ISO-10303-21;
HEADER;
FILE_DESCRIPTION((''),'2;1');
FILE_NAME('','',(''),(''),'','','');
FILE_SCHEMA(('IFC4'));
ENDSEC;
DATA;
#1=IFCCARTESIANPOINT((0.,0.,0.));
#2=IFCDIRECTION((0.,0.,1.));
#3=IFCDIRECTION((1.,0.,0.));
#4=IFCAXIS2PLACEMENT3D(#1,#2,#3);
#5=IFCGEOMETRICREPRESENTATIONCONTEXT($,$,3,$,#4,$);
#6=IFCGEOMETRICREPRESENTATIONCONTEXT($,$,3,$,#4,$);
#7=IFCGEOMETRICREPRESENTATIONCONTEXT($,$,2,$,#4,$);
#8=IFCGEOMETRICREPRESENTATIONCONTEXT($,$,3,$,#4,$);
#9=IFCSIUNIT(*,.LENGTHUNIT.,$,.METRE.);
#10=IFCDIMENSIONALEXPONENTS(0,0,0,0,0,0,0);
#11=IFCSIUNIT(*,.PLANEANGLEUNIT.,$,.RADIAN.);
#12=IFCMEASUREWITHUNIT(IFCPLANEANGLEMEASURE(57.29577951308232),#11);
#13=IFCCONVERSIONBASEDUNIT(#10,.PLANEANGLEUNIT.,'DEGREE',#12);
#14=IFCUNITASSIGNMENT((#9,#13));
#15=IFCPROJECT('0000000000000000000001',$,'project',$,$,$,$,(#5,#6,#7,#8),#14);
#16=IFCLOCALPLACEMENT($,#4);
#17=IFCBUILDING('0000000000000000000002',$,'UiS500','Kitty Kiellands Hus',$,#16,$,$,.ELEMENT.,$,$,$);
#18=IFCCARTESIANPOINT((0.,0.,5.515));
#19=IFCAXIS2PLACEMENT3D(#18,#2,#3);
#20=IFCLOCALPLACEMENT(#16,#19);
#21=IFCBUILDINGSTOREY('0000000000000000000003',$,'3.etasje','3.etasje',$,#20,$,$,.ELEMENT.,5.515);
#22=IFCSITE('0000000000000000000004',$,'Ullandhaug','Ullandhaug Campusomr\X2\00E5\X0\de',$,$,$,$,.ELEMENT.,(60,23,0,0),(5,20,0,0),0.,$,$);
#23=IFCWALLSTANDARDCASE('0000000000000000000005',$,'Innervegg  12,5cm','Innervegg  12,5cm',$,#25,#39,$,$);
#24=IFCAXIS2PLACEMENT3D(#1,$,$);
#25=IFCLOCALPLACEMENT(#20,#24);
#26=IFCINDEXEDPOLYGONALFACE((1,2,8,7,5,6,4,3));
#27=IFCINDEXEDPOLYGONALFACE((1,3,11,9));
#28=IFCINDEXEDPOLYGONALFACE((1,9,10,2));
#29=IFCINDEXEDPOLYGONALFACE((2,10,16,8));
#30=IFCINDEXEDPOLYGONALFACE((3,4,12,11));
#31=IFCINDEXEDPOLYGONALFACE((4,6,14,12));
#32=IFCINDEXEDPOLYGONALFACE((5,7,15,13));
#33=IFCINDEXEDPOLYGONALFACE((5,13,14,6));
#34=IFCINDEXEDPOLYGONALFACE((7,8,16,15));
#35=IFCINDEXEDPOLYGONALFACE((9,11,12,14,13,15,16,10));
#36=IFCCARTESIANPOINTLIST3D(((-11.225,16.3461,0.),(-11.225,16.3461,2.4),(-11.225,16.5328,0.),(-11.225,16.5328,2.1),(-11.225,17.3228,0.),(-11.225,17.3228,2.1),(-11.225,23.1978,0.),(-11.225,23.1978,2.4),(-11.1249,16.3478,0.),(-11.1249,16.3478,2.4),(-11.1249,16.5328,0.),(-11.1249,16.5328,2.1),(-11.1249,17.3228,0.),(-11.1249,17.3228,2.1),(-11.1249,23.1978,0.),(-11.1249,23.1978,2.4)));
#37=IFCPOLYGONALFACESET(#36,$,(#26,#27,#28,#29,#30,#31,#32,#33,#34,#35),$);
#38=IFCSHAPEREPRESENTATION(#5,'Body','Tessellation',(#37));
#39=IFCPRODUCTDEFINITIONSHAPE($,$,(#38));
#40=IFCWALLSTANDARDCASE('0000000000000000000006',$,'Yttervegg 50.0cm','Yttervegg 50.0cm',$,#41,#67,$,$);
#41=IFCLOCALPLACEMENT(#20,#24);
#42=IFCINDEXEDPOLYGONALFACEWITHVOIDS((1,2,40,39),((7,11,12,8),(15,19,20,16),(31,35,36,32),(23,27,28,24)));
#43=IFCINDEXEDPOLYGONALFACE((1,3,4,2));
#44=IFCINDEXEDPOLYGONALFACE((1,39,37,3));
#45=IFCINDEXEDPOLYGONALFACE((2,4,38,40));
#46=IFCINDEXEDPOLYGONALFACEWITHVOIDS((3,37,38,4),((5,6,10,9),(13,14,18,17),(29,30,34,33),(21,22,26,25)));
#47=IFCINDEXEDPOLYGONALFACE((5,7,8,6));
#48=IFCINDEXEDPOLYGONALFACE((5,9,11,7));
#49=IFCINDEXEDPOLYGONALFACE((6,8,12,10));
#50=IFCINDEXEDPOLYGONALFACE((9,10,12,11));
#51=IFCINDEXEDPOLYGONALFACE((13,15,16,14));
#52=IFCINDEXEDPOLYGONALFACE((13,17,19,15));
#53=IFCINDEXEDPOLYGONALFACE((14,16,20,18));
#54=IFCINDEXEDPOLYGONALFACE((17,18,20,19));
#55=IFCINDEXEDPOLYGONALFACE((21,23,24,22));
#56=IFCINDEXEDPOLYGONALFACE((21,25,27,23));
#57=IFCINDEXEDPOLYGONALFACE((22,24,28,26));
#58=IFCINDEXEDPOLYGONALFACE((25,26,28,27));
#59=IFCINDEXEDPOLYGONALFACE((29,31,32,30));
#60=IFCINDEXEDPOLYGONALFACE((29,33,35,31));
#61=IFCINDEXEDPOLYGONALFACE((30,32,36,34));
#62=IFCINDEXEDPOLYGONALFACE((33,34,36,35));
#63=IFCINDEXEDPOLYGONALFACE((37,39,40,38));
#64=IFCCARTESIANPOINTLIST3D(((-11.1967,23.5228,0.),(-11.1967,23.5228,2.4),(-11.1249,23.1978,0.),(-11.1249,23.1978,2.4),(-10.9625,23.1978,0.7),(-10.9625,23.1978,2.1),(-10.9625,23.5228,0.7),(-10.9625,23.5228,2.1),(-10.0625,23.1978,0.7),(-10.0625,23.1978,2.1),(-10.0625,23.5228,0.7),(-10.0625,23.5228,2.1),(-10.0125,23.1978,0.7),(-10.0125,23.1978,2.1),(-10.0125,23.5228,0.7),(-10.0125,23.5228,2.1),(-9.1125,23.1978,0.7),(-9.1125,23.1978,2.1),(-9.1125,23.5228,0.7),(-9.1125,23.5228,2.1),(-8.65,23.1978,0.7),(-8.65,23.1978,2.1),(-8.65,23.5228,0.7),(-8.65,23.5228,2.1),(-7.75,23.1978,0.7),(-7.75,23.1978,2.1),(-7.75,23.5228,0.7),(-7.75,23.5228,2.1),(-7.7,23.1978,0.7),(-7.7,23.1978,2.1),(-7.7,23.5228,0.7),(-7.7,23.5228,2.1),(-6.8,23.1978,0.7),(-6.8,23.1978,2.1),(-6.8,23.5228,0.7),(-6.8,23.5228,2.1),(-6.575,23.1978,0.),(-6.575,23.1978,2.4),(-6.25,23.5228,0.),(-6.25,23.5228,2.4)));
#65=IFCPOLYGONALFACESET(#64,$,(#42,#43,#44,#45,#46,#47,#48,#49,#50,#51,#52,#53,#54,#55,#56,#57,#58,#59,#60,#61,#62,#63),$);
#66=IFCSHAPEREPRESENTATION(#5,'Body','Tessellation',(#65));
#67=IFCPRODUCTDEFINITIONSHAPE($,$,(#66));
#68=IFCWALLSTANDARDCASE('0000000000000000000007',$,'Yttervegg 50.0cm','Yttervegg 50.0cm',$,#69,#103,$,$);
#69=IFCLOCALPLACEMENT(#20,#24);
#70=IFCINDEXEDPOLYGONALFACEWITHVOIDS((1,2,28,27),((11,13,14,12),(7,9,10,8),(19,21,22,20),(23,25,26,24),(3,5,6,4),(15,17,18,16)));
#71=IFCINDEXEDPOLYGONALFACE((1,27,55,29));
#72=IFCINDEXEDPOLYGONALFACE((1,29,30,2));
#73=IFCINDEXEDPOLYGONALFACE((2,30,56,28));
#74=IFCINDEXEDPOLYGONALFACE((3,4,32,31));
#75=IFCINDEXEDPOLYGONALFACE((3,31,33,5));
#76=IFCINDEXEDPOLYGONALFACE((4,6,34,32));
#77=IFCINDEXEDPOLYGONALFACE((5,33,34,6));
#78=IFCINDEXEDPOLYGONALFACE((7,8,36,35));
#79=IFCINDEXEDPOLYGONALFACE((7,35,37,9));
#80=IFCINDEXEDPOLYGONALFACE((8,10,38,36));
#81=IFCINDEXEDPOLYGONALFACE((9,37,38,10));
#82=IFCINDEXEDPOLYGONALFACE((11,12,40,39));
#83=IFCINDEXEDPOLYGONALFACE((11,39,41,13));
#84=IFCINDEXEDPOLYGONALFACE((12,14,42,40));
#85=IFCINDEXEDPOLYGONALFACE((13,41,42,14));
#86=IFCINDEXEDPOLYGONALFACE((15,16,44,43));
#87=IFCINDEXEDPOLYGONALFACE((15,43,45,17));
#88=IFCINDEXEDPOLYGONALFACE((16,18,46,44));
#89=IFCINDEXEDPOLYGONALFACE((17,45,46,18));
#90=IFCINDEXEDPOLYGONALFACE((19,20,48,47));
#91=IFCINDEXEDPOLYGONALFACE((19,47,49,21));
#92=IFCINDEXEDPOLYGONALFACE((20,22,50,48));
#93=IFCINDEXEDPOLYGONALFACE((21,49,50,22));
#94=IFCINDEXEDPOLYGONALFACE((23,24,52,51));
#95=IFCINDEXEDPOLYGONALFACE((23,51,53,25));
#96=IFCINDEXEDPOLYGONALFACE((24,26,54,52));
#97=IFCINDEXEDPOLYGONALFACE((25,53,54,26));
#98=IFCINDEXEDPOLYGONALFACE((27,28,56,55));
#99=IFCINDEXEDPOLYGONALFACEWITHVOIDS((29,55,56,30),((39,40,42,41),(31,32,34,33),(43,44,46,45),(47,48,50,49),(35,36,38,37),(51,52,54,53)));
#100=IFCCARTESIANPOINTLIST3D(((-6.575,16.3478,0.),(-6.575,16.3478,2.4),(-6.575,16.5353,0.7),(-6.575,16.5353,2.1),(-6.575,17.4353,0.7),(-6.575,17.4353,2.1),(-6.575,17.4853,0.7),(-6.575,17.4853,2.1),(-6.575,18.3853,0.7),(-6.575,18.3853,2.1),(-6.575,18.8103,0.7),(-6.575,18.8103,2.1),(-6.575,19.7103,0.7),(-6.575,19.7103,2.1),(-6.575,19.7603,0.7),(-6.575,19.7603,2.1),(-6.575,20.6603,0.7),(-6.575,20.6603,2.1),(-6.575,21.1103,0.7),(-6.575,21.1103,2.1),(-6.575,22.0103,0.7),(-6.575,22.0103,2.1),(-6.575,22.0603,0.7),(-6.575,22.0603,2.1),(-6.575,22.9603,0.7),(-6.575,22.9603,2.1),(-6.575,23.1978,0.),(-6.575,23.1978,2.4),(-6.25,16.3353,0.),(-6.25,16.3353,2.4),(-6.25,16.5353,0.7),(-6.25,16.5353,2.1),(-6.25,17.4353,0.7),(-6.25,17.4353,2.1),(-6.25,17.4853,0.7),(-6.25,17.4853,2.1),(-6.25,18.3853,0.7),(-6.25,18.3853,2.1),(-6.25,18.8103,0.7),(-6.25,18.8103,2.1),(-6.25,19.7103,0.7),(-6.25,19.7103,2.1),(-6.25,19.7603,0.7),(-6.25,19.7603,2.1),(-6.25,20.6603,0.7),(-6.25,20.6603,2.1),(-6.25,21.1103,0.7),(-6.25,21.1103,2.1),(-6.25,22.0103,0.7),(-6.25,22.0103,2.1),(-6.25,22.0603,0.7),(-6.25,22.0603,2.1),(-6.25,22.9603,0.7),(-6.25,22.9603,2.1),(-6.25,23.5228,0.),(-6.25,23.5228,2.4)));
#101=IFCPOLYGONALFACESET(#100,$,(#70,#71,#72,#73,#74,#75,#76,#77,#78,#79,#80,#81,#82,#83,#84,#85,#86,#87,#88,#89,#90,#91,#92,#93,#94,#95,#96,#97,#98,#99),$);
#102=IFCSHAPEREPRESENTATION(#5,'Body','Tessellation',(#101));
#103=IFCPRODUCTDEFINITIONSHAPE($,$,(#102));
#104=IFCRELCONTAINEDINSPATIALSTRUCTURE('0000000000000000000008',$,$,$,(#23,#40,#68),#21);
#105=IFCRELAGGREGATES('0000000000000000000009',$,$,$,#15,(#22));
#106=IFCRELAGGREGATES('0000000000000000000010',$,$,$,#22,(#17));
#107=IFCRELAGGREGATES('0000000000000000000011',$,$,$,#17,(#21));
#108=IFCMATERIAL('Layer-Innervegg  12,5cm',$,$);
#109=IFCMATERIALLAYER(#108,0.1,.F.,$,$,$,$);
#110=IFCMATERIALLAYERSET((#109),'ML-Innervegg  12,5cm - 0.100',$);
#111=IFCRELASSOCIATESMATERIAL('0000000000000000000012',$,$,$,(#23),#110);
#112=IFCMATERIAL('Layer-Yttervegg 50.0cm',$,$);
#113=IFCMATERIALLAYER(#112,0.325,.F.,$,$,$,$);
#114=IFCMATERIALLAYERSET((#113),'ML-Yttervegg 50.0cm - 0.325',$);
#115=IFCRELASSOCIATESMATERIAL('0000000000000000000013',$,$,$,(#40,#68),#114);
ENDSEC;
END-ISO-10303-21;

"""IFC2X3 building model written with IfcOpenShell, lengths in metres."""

from ifc_helpers import new_model, entity, si_unit, converted_unit, frame, origin_with_axes, place, context, project, spatial, polyline, outline, extrude, material, layer, layer_set, layer_usage, element, save


model = new_model("IFC2X3")

# Units and contexts
context_of_model_1 = context(None, 3, world=origin_with_axes())
context_of_model_2 = context(None, 3, world=origin_with_axes())
context_of_model_3 = context(None, 2, world=origin_with_axes())
context_of_model_4 = context(None, 3, world=origin_with_axes())
ifc_project = project(units=[si_unit("LENGTHUNIT", "METRE"), converted_unit("PLANEANGLEUNIT", "DEGREE", entity("IfcPlaneAngleMeasure", 57.29577951308232), si_unit("PLANEANGLEUNIT", "RADIAN"), dimensions=[0, 0, 0, 0, 0, 0, 0])], contexts=[context_of_model_1, context_of_model_2, context_of_model_3, context_of_model_4])

# Site, building, storey
site = spatial("IfcSite", under=ifc_project, Name="Ullandhaug", Description="Ullandhaug Campusområde", CompositionType="ELEMENT", RefLatitude=(60, 23, 0, 0), RefLongitude=(5, 20, 0, 0), RefElevation=0.0)
building_placement = place(None, origin_with_axes())
building = spatial("IfcBuilding", under=site, at=building_placement, Name="UiS500", Description="Kitty Kiellands Hus", CompositionType="ELEMENT")
storey_placement = place(building_placement, frame((0.0, 0.0, 5.515), z_axis=(0.0, 0.0, 1.0), x_axis=(1.0, 0.0, 0.0)))
storey = spatial("IfcBuildingStorey", under=building, at=storey_placement, Name="3.etasje", Description="3.etasje", CompositionType="ELEMENT", Elevation=5.515)

# Shared definitions
ifc_material_1 = material(Name="Layer-Innervegg  12,5cm")
ifc_layer_1 = layer(ifc_material_1, 0.1, ventilated=False)
ifc_layer_set_1 = layer_set([ifc_layer_1], Name="ML-Innervegg  12,5cm - 0.100")
ifc_layer_usage_1 = layer_usage(ifc_layer_set_1, "AXIS2", "POSITIVE", 0.0)

# Shared definitions
ifc_material_2 = material(Name="Layer-Yttervegg 50.0cm")
ifc_layer_2 = layer(ifc_material_2, 0.325, ventilated=False)
ifc_layer_set_2 = layer_set([ifc_layer_2], Name="ML-Yttervegg 50.0cm - 0.325")
ifc_layer_usage_2 = layer_usage(ifc_layer_set_2, "AXIS2", "POSITIVE", 0.0)

# Wall, opening
wall_1_placement = place(storey_placement, frame((-11.1249, 16.3478, 0.0), z_axis=(0.0, 0.0, 1.0), x_axis=(0.0, 1.0, 0.0)))
wall_1 = element("IfcWallStandardCase", 1, at=wall_1_placement, inside=storey, material=ifc_layer_usage_1, Name="Innervegg  12,5cm", Description="Innervegg  12,5cm", context=context_of_model_1, shape_type="SweptSolid", body=[
    extrude(outline(polyline([(0.0, 0.0), (6.85, 0.0), (6.85, 0.1001), (-0.0017, 0.1001), (0.0, 0.0)])), frame((0.0, 0.0, 0.0), z_axis=(0.0, 0.0, 1.0), x_axis=(1.0, 0.0, 0.0)), (0.0, 0.0, 1.0), 2.4),
])
opening_1_placement = place(wall_1_placement, frame((0.185, 0.1001, 0.0), z_axis=(0.0, 0.0, 1.0), x_axis=(1.0, 0.0, 0.0)))
element("IfcOpeningElement", 2, at=opening_1_placement, cuts=wall_1, context=context_of_model_1, shape_type="SweptSolid", body=[
    extrude(outline(polyline([(0.0, 0.0), (2.1, 0.0), (2.1, 0.79), (0.0, 0.79), (0.0, 0.0)])), frame((0.0, 0.0, 0.0), z_axis=(0.0, 1.0, 0.0), x_axis=(0.0, 0.0, 1.0)), (0.0, 0.0, -1.0), 0.1001),
])

# Walls, openings
wall_2_placement = place(storey_placement, frame((-6.25, 23.5228, 0.0), z_axis=(0.0, 0.0, 1.0), x_axis=(-1.0, 0.0, 0.0)))
wall_2 = element("IfcWallStandardCase", 3, at=wall_2_placement, inside=storey, material=ifc_layer_usage_2, Name="Yttervegg 50.0cm", Description="Yttervegg 50.0cm", context=context_of_model_1, shape_type="SweptSolid", body=[
    extrude(outline(polyline([(0.0, 0.0), (4.9467, 0.0), (4.8749, 0.325), (0.325, 0.325), (0.0, 0.0)])), frame((0.0, 0.0, 0.0), z_axis=(0.0, 0.0, 1.0), x_axis=(1.0, 0.0, 0.0)), (0.0, 0.0, 1.0), 2.4),
])
opening_2_placement = place(wall_2_placement, frame((1.5, 0.325, 0.7), z_axis=(0.0, 0.0, 1.0), x_axis=(1.0, 0.0, 0.0)))
element("IfcOpeningElement", 4, at=opening_2_placement, cuts=wall_2, context=context_of_model_1, shape_type="SweptSolid", body=[
    extrude(outline(polyline([(0.0, 0.0), (1.4, 0.0), (1.4, 0.9), (0.0, 0.9), (0.0, 0.0)])), frame((0.0, 0.0, 0.0), z_axis=(0.0, 1.0, 0.0), x_axis=(0.0, 0.0, 1.0)), (0.0, 0.0, -1.0), 0.325),
])
opening_3_placement = place(wall_2_placement, frame((0.55, 0.325, 0.7), z_axis=(0.0, 0.0, 1.0), x_axis=(1.0, 0.0, 0.0)))
element("IfcOpeningElement", 5, at=opening_3_placement, cuts=wall_2, context=context_of_model_1, shape_type="SweptSolid", body=[
    extrude(outline(polyline([(0.0, 0.0), (1.4, 0.0), (1.4, 0.9), (0.0, 0.9), (0.0, 0.0)])), frame((0.0, 0.0, 0.0), z_axis=(0.0, 1.0, 0.0), x_axis=(0.0, 0.0, 1.0)), (0.0, 0.0, -1.0), 0.325),
])
opening_4_placement = place(wall_2_placement, frame((2.8625, 0.325, 0.7), z_axis=(0.0, 0.0, 1.0), x_axis=(1.0, 0.0, 0.0)))
element("IfcOpeningElement", 6, at=opening_4_placement, cuts=wall_2, context=context_of_model_1, shape_type="SweptSolid", body=[
    extrude(outline(polyline([(0.0, 0.0), (1.4, 0.0), (1.4, 0.9), (0.0, 0.9), (0.0, 0.0)])), frame((0.0, 0.0, 0.0), z_axis=(0.0, 1.0, 0.0), x_axis=(0.0, 0.0, 1.0)), (0.0, 0.0, -1.0), 0.325),
])
opening_5_placement = place(wall_2_placement, frame((3.8125, 0.325, 0.7), z_axis=(0.0, 0.0, 1.0), x_axis=(1.0, 0.0, 0.0)))
element("IfcOpeningElement", 7, at=opening_5_placement, cuts=wall_2, context=context_of_model_1, shape_type="SweptSolid", body=[
    extrude(outline(polyline([(0.0, 0.0), (1.4, 0.0), (1.4, 0.9), (0.0, 0.9), (0.0, 0.0)])), frame((0.0, 0.0, 0.0), z_axis=(0.0, 1.0, 0.0), x_axis=(0.0, 0.0, 1.0)), (0.0, 0.0, -1.0), 0.325),
])
wall_3_placement = place(storey_placement, frame((-6.25, 16.3353, 0.0), z_axis=(0.0, 0.0, 1.0), x_axis=(0.0, 1.0, 0.0)))
wall_3 = element("IfcWallStandardCase", 8, at=wall_3_placement, inside=storey, material=ifc_layer_usage_2, Name="Yttervegg 50.0cm", Description="Yttervegg 50.0cm", context=context_of_model_1, shape_type="SweptSolid", body=[
    extrude(outline(polyline([(0.0, 0.0), (7.1875, 0.0), (6.8625, 0.325), (0.0125, 0.325), (0.0, 0.0)])), frame((0.0, 0.0, 0.0), z_axis=(0.0, 0.0, 1.0), x_axis=(1.0, 0.0, 0.0)), (0.0, 0.0, 1.0), 2.4),
])
opening_6_placement = place(wall_3_placement, frame((0.2, 0.325, 0.7), z_axis=(0.0, 0.0, 1.0), x_axis=(1.0, 0.0, 0.0)))
element("IfcOpeningElement", 9, at=opening_6_placement, cuts=wall_3, context=context_of_model_1, shape_type="SweptSolid", body=[
    extrude(outline(polyline([(0.0, 0.0), (1.4, 0.0), (1.4, 0.9), (0.0, 0.9), (0.0, 0.0)])), frame((0.0, 0.0, 0.0), z_axis=(0.0, 1.0, 0.0), x_axis=(0.0, 0.0, 1.0)), (0.0, 0.0, -1.0), 0.325),
])
opening_7_placement = place(wall_3_placement, frame((1.15, 0.325, 0.7), z_axis=(0.0, 0.0, 1.0), x_axis=(1.0, 0.0, 0.0)))
element("IfcOpeningElement", 10, at=opening_7_placement, cuts=wall_3, context=context_of_model_1, shape_type="SweptSolid", body=[
    extrude(outline(polyline([(0.0, 0.0), (1.4, 0.0), (1.4, 0.9), (0.0, 0.9), (0.0, 0.0)])), frame((0.0, 0.0, 0.0), z_axis=(0.0, 1.0, 0.0), x_axis=(0.0, 0.0, 1.0)), (0.0, 0.0, -1.0), 0.325),
])
opening_8_placement = place(wall_3_placement, frame((2.475, 0.325, 0.7), z_axis=(0.0, 0.0, 1.0), x_axis=(1.0, 0.0, 0.0)))
element("IfcOpeningElement", 11, at=opening_8_placement, cuts=wall_3, context=context_of_model_1, shape_type="SweptSolid", body=[
    extrude(outline(polyline([(0.0, 0.0), (1.4, 0.0), (1.4, 0.9), (0.0, 0.9), (0.0, 0.0)])), frame((0.0, 0.0, 0.0), z_axis=(0.0, 1.0, 0.0), x_axis=(0.0, 0.0, 1.0)), (0.0, 0.0, -1.0), 0.325),
])
opening_9_placement = place(wall_3_placement, frame((3.425, 0.325, 0.7), z_axis=(0.0, 0.0, 1.0), x_axis=(1.0, 0.0, 0.0)))
element("IfcOpeningElement", 12, at=opening_9_placement, cuts=wall_3, context=context_of_model_1, shape_type="SweptSolid", body=[
    extrude(outline(polyline([(0.0, 0.0), (1.4, 0.0), (1.4, 0.9), (0.0, 0.9), (0.0, 0.0)])), frame((0.0, 0.0, 0.0), z_axis=(0.0, 1.0, 0.0), x_axis=(0.0, 0.0, 1.0)), (0.0, 0.0, -1.0), 0.325),
])
opening_10_placement = place(wall_3_placement, frame((4.775, 0.325, 0.7), z_axis=(0.0, 0.0, 1.0), x_axis=(1.0, 0.0, 0.0)))
element("IfcOpeningElement", 13, at=opening_10_placement, cuts=wall_3, context=context_of_model_1, shape_type="SweptSolid", body=[
    extrude(outline(polyline([(0.0, 0.0), (1.4, 0.0), (1.4, 0.9), (0.0, 0.9), (0.0, 0.0)])), frame((0.0, 0.0, 0.0), z_axis=(0.0, 1.0, 0.0), x_axis=(0.0, 0.0, 1.0)), (0.0, 0.0, -1.0), 0.325),
])
opening_11_placement = place(wall_3_placement, frame((5.725, 0.325, 0.7), z_axis=(0.0, 0.0, 1.0), x_axis=(1.0, 0.0, 0.0)))
element("IfcOpeningElement", 14, at=opening_11_placement, cuts=wall_3, context=context_of_model_1, shape_type="SweptSolid", body=[
    extrude(outline(polyline([(0.0, 0.0), (1.4, 0.0), (1.4, 0.9), (0.0, 0.9), (0.0, 0.0)])), frame((0.0, 0.0, 0.0), z_axis=(0.0, 1.0, 0.0), x_axis=(0.0, 0.0, 1.0)), (0.0, 0.0, -1.0), 0.325),
])

save(model, "model.ifc")
